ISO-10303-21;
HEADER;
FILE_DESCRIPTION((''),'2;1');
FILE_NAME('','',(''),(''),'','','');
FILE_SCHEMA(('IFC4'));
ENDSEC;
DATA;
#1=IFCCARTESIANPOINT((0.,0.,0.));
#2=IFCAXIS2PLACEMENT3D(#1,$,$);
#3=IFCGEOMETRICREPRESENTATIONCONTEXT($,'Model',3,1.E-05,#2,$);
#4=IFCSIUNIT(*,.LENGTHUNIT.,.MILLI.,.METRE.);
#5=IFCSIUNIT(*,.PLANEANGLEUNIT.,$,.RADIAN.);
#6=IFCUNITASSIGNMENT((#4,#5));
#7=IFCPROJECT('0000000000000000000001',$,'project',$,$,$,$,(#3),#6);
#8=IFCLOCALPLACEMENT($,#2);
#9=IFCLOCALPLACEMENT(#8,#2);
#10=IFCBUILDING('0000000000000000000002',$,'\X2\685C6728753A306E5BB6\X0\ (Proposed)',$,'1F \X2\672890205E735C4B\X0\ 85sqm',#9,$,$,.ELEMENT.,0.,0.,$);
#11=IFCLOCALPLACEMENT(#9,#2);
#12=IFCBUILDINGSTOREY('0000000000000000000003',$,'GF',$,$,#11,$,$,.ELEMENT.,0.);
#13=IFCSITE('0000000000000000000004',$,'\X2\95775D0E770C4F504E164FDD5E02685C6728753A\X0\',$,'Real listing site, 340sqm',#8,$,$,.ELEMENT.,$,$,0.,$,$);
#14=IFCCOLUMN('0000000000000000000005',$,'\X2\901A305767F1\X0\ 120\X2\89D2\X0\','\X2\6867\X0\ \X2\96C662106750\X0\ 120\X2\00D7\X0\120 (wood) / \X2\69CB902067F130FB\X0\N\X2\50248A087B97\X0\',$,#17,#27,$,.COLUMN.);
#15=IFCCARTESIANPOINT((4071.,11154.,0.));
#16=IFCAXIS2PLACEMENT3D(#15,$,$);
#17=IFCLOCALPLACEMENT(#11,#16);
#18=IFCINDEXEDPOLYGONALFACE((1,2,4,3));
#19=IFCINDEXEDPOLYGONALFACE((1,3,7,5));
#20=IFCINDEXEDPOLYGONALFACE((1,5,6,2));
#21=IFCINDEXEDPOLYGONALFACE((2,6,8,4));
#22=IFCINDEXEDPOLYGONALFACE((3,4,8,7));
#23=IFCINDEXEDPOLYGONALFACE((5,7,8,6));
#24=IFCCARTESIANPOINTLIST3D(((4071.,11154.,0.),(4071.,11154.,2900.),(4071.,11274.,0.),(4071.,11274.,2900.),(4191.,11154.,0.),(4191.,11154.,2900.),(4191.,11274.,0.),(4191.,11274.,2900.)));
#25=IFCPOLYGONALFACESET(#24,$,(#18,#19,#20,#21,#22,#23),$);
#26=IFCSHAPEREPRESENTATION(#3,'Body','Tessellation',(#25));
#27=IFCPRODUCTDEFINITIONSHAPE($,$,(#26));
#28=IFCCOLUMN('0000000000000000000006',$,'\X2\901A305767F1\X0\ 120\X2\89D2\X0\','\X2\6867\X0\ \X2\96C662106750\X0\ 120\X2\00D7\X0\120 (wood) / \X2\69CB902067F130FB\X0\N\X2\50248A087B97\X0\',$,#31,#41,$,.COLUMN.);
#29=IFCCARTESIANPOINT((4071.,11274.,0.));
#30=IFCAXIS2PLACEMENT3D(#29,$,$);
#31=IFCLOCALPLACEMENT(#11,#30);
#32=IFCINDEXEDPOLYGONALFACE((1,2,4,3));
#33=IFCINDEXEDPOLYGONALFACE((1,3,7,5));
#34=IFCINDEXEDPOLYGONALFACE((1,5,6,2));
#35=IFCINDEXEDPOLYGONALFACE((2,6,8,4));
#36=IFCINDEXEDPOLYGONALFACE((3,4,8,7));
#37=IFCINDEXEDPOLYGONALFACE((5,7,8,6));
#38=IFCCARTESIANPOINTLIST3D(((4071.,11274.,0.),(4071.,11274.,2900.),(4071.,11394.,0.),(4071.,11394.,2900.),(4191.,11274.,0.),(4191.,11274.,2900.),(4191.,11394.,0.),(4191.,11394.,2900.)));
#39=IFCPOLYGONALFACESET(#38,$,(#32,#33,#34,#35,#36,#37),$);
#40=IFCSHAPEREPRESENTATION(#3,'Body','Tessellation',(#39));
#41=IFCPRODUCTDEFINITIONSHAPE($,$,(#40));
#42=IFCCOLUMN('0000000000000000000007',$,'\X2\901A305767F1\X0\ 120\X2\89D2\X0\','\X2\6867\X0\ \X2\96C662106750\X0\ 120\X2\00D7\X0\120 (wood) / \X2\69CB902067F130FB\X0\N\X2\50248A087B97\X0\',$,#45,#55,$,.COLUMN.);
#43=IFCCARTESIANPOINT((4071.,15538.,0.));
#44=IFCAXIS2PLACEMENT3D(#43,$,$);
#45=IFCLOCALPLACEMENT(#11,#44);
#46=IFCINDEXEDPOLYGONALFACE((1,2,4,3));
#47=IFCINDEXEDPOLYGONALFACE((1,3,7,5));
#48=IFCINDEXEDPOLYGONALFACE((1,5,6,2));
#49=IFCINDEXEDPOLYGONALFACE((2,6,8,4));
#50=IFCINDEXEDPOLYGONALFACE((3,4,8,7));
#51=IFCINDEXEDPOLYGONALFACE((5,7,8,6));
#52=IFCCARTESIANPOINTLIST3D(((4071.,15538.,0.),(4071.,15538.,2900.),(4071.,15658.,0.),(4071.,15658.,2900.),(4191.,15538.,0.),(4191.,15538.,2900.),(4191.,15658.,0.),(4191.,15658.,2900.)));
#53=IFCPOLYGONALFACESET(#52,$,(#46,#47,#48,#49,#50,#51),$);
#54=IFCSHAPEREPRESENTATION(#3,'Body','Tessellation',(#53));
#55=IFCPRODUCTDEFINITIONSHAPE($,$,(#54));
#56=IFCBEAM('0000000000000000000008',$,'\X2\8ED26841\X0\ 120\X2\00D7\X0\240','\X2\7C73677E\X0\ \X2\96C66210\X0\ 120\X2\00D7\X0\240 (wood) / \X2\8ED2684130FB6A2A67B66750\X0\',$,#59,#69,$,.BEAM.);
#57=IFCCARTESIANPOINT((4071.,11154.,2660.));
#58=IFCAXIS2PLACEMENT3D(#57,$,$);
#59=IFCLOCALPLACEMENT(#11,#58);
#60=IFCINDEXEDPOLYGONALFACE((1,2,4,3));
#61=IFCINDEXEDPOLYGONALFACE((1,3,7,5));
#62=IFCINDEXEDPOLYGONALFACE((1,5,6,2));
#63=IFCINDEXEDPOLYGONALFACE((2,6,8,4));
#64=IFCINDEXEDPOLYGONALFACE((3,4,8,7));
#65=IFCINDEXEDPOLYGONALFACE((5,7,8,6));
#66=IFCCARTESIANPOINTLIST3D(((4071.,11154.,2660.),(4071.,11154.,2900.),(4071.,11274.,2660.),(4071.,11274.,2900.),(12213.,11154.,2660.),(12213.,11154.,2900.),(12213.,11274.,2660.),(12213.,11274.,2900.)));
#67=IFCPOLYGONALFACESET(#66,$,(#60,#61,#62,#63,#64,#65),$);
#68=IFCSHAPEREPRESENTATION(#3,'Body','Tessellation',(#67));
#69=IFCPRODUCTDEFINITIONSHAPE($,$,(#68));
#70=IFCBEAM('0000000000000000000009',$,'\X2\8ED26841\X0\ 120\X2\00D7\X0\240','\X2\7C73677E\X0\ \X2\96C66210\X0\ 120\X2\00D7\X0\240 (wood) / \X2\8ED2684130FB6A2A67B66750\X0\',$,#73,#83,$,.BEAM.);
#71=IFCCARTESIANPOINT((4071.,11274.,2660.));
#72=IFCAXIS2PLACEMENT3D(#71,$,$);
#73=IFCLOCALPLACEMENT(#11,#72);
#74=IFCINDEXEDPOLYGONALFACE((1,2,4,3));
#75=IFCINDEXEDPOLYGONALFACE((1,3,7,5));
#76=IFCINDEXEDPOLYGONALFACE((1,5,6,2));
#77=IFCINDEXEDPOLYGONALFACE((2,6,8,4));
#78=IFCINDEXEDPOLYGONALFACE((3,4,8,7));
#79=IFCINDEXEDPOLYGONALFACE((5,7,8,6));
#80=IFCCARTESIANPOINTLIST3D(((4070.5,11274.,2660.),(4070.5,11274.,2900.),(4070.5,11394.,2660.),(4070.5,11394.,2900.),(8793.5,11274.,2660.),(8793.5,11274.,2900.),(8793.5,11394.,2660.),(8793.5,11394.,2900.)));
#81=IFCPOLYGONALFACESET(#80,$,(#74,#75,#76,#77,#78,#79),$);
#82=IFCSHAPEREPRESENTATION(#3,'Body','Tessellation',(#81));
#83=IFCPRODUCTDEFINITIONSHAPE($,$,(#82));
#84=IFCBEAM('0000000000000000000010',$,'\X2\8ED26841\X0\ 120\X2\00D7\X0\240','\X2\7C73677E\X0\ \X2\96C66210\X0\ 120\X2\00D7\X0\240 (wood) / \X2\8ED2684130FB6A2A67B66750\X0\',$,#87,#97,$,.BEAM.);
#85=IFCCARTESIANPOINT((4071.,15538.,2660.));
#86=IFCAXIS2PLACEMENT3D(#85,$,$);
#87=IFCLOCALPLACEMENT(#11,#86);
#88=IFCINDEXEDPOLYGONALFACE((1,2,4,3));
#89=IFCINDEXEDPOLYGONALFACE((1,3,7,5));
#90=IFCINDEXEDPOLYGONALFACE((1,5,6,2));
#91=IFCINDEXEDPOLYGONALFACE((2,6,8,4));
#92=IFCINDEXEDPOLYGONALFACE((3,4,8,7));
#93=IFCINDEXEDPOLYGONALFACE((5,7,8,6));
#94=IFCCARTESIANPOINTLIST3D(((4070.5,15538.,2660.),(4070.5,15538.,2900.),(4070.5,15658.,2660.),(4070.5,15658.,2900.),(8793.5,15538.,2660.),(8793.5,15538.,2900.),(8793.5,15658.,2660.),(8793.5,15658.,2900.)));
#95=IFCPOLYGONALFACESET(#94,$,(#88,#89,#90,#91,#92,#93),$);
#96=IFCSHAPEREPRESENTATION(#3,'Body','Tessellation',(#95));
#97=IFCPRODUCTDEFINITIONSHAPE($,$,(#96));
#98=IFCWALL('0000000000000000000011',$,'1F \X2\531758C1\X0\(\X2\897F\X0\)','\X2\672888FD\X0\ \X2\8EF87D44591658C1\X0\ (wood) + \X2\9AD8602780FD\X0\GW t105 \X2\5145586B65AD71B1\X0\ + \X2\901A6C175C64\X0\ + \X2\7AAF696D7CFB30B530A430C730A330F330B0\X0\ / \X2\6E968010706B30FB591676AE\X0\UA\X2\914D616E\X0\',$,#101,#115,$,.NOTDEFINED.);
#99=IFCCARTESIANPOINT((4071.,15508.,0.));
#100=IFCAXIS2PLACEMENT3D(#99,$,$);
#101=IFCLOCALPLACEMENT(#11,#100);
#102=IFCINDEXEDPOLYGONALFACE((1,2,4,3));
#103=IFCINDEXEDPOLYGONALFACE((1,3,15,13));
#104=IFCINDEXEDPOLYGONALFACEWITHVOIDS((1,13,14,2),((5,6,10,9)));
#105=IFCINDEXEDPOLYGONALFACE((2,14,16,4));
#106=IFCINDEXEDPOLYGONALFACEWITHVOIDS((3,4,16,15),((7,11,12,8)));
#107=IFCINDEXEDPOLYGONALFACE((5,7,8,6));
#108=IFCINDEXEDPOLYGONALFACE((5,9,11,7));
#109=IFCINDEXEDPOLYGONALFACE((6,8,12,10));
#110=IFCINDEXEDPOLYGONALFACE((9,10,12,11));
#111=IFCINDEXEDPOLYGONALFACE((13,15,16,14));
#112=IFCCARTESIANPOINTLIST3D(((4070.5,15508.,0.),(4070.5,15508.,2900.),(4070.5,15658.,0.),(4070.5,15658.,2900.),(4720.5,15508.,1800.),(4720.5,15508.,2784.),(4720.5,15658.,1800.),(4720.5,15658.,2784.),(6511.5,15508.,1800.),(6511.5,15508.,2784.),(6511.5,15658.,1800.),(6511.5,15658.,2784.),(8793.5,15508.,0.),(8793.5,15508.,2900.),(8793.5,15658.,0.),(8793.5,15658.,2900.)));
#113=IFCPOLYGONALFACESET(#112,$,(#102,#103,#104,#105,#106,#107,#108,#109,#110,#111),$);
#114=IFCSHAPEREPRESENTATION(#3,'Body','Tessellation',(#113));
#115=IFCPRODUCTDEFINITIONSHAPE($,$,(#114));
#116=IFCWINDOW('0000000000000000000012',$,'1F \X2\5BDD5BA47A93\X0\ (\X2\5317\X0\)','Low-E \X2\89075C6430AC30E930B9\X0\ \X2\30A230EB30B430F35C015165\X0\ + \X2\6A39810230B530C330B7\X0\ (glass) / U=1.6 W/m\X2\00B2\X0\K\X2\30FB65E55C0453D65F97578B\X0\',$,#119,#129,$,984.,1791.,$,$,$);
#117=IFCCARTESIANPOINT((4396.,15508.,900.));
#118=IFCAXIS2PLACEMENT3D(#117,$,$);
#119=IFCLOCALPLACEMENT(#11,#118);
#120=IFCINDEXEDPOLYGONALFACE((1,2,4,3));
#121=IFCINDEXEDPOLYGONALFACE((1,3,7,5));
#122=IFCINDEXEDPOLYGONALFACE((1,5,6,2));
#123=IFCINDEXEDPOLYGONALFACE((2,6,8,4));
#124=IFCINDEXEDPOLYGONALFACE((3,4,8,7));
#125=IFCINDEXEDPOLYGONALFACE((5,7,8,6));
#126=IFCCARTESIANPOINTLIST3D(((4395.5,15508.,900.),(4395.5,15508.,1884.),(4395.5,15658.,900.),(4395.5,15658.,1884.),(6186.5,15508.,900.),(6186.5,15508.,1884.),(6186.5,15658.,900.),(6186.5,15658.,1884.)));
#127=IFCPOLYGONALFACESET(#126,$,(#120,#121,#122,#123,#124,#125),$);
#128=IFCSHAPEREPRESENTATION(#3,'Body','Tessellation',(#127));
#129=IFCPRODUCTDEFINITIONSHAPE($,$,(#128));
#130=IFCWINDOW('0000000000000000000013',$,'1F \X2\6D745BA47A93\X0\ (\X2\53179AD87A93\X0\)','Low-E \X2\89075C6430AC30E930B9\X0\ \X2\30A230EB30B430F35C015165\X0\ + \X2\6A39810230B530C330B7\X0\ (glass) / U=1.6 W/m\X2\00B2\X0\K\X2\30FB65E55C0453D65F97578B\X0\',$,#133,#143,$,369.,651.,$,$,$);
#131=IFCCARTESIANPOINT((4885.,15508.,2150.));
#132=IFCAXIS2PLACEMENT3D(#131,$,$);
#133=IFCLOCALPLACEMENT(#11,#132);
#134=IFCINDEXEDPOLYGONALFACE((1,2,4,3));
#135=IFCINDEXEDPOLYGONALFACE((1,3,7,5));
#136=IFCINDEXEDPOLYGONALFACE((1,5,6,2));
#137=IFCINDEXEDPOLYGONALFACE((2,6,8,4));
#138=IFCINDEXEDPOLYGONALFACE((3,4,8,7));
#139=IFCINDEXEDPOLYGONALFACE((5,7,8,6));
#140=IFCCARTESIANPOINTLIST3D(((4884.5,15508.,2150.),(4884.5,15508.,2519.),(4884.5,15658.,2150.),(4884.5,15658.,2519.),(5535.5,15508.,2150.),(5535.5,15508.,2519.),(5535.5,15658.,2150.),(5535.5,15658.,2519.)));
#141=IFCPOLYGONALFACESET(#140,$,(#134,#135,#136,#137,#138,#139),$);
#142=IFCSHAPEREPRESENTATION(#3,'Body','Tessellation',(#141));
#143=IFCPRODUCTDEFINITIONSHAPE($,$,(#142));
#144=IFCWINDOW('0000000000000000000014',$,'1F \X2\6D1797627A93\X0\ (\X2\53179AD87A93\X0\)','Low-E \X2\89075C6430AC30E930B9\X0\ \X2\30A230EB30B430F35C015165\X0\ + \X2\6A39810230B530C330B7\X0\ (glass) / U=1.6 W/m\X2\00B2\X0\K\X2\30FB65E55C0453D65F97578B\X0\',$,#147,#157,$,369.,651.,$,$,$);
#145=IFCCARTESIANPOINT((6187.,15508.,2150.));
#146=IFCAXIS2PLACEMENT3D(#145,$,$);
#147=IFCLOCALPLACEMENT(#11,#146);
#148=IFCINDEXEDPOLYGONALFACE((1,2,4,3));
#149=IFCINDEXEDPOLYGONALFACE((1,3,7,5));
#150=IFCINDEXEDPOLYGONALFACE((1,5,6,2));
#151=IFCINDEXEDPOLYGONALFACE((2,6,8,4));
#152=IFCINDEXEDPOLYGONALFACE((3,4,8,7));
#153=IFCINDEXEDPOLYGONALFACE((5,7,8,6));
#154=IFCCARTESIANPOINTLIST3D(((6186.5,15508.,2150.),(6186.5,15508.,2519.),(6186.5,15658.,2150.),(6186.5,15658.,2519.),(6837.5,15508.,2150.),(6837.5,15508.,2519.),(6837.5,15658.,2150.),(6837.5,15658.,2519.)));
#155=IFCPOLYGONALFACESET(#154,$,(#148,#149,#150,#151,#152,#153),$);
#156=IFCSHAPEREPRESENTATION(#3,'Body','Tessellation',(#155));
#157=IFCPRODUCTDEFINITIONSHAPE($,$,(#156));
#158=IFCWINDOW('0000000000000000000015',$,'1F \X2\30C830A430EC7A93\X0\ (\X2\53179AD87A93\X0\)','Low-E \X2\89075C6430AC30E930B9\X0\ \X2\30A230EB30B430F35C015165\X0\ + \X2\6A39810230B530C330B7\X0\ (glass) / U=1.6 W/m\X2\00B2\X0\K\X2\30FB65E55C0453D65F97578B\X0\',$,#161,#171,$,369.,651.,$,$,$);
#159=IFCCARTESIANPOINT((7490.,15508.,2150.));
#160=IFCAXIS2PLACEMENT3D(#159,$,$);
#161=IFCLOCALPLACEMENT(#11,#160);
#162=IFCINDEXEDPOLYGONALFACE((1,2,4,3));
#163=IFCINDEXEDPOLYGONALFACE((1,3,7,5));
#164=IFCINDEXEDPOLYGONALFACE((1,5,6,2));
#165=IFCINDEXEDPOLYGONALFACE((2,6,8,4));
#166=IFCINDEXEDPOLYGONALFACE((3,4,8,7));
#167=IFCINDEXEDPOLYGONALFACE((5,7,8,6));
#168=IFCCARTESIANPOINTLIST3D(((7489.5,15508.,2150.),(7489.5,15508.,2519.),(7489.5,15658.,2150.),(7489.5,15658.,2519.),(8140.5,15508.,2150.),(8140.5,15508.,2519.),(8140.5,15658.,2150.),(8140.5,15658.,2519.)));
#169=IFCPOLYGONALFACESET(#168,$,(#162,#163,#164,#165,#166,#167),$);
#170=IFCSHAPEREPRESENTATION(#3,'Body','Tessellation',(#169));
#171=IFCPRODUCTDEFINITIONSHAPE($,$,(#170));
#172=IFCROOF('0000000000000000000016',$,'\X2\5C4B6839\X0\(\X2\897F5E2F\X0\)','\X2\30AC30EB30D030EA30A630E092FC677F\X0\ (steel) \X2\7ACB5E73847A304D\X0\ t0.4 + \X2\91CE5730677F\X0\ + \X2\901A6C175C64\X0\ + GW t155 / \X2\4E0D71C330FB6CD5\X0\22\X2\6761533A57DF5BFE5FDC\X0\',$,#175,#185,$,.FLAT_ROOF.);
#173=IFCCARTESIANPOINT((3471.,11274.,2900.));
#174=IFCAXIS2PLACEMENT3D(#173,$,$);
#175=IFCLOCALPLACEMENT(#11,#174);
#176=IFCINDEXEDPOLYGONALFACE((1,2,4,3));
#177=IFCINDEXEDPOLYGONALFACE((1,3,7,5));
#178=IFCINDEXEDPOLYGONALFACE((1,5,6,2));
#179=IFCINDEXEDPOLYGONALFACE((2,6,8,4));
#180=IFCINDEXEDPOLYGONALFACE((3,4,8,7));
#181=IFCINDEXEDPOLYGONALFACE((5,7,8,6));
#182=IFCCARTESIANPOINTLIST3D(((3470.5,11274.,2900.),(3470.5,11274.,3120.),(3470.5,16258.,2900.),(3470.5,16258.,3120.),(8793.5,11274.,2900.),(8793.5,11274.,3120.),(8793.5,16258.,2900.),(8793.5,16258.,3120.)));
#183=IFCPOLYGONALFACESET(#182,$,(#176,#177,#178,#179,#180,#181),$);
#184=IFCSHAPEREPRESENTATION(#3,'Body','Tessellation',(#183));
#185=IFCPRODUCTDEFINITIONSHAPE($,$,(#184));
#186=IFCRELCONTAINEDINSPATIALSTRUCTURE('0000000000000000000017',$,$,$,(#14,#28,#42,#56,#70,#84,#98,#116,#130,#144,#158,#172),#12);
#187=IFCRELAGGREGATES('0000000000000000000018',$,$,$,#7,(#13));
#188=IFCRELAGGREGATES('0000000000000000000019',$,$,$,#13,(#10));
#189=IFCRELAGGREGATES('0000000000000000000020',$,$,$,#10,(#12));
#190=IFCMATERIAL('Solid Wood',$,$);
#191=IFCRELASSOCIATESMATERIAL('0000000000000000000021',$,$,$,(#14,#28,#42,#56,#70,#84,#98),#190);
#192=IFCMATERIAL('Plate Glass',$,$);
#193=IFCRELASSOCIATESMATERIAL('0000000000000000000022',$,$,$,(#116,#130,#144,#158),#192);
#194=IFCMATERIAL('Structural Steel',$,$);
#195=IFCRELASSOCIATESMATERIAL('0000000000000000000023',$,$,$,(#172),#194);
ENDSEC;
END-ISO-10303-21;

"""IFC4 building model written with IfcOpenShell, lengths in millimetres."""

from ifc_helpers import new_model, si_unit, frame, frame_2d, origin, place, context, project, spatial, rectangle, extrude, material, element, fill, save


model = new_model("IFC4")

# Units and contexts
model_context = context("Model", 3, precision=1e-05, world=origin())
ifc_project = project(units=[si_unit("LENGTHUNIT", "METRE", prefix="MILLI"), si_unit("PLANEANGLEUNIT", "RADIAN")], contexts=[model_context])

# Site, building, storey
site_placement = place(None, origin())
site = spatial("IfcSite", under=ifc_project, at=site_placement, Name="長崎県佐世保市桜木町", ObjectType="Real listing site, 340sqm", CompositionType="ELEMENT", RefElevation=0.0)
building_placement = place(site_placement, origin())
building = spatial("IfcBuilding", under=site, at=building_placement, Name="桜木町の家 (Proposed)", ObjectType="1F 木造平屋 85sqm", CompositionType="ELEMENT", ElevationOfRefHeight=0.0, ElevationOfTerrain=0.0)
storey_placement = place(building_placement, origin())
storey = spatial("IfcBuildingStorey", under=building, at=storey_placement, Name="GF", CompositionType="ELEMENT", Elevation=0.0)

# Columns
ifc_material_1 = material(Name="Solid Wood")
column_1_placement = place(storey_placement, frame((4071.0, 11154.0, 0.0)))
element("IfcColumn", 1, at=column_1_placement, inside=storey, material=ifc_material_1, Name="通し柱 120角", Description="桧 集成材 120×120 (wood) / 構造柱・N値計算", PredefinedType="COLUMN", context=model_context, shape_type="SweptSolid", body=[
    extrude(rectangle(XDim=120.0, YDim=120.0, at=frame_2d((60.0, 60.0))), frame((4071.0, 11154.0, 0.0)), (0.0, 0.0, 1.0), 2900.0),
])
column_2_placement = place(storey_placement, frame((4071.0, 11274.0, 0.0)))
element("IfcColumn", 2, at=column_2_placement, inside=storey, material=ifc_material_1, Name="通し柱 120角", Description="桧 集成材 120×120 (wood) / 構造柱・N値計算", PredefinedType="COLUMN", context=model_context, shape_type="SweptSolid", body=[
    extrude(rectangle(XDim=120.0, YDim=120.0, at=frame_2d((60.0, 60.0))), frame((4071.0, 11274.0, 0.0)), (0.0, 0.0, 1.0), 2900.0),
])
column_3_placement = place(storey_placement, frame((4071.0, 15538.0, 0.0)))
element("IfcColumn", 3, at=column_3_placement, inside=storey, material=ifc_material_1, Name="通し柱 120角", Description="桧 集成材 120×120 (wood) / 構造柱・N値計算", PredefinedType="COLUMN", context=model_context, shape_type="SweptSolid", body=[
    extrude(rectangle(XDim=120.0, YDim=120.0, at=frame_2d((60.0, 60.0))), frame((4071.0, 15538.0, 0.0)), (0.0, 0.0, 1.0), 2900.0),
])

# Beams
beam_1_placement = place(storey_placement, frame((4071.0, 11154.0, 2660.0)))
element("IfcBeam", 4, at=beam_1_placement, inside=storey, material=ifc_material_1, Name="軒桁 120×240", Description="米松 集成 120×240 (wood) / 軒桁・横架材", PredefinedType="BEAM", context=model_context, shape_type="SweptSolid", body=[
    extrude(rectangle(XDim=8142.0, YDim=120.0, at=frame_2d((4071.0, 60.0))), frame((4071.0, 11154.0, 2660.0)), (0.0, 0.0, 1.0), 240.0),
])
beam_2_placement = place(storey_placement, frame((4071.0, 11274.0, 2660.0)))
element("IfcBeam", 5, at=beam_2_placement, inside=storey, material=ifc_material_1, Name="軒桁 120×240", Description="米松 集成 120×240 (wood) / 軒桁・横架材", PredefinedType="BEAM", context=model_context, shape_type="SweptSolid", body=[
    extrude(rectangle(XDim=4723.0, YDim=120.0, at=frame_2d((2361.0, 60.0))), frame((4071.0, 11274.0, 2660.0)), (0.0, 0.0, 1.0), 240.0),
])
beam_3_placement = place(storey_placement, frame((4071.0, 15538.0, 2660.0)))
element("IfcBeam", 6, at=beam_3_placement, inside=storey, material=ifc_material_1, Name="軒桁 120×240", Description="米松 集成 120×240 (wood) / 軒桁・横架材", PredefinedType="BEAM", context=model_context, shape_type="SweptSolid", body=[
    extrude(rectangle(XDim=4723.0, YDim=120.0, at=frame_2d((2361.0, 60.0))), frame((4071.0, 15538.0, 2660.0)), (0.0, 0.0, 1.0), 240.0),
])

# Wall, openings, windows
wall_1_placement = place(storey_placement, frame((4071.0, 15508.0, 0.0)))
wall_1 = element("IfcWall", 7, at=wall_1_placement, inside=storey, material=ifc_material_1, Name="1F 北壁(西)", Description="木製 軸組外壁 (wood) + 高性能GW t105 充填断熱 + 通気層 + 窯業系サイディング / 準耐火・外皮UA配慮", PredefinedType="NOTDEFINED", context=model_context, shape_type="SweptSolid", body=[
    extrude(rectangle(XDim=4723.0, YDim=150.0, at=frame_2d((2361.0, 75.0))), frame((4071.0, 15508.0, 0.0)), (0.0, 0.0, 1.0), 2900.0),
])
opening_1_placement = place(storey_placement, frame((4396.0, 15508.0, 900.0)))
opening_1 = element("IfcOpeningElement", 8, at=opening_1_placement, cuts=wall_1, PredefinedType="NOTDEFINED", context=model_context, shape_type="SweptSolid", body=[
    extrude(rectangle(XDim=1791.0, YDim=150.0, at=frame_2d((895.0, 75.0))), frame((4396.0, 15508.0, 900.0)), (0.0, 0.0, 1.0), 984.0),
])
opening_2_placement = place(storey_placement, frame((4885.0, 15508.0, 2150.0)))
opening_2 = element("IfcOpeningElement", 9, at=opening_2_placement, cuts=wall_1, PredefinedType="NOTDEFINED", context=model_context, shape_type="SweptSolid", body=[
    extrude(rectangle(XDim=651.0, YDim=150.0, at=frame_2d((325.0, 75.0))), frame((4885.0, 15508.0, 2150.0)), (0.0, 0.0, 1.0), 369.0),
])
opening_3_placement = place(storey_placement, frame((6187.0, 15508.0, 2150.0)))
opening_3 = element("IfcOpeningElement", 10, at=opening_3_placement, cuts=wall_1, PredefinedType="NOTDEFINED", context=model_context, shape_type="SweptSolid", body=[
    extrude(rectangle(XDim=651.0, YDim=150.0, at=frame_2d((325.0, 75.0))), frame((6187.0, 15508.0, 2150.0)), (0.0, 0.0, 1.0), 369.0),
])
opening_4_placement = place(storey_placement, frame((7490.0, 15508.0, 2150.0)))
opening_4 = element("IfcOpeningElement", 11, at=opening_4_placement, cuts=wall_1, PredefinedType="NOTDEFINED", context=model_context, shape_type="SweptSolid", body=[
    extrude(rectangle(XDim=651.0, YDim=150.0, at=frame_2d((325.0, 75.0))), frame((7490.0, 15508.0, 2150.0)), (0.0, 0.0, 1.0), 369.0),
])
ifc_material_2 = material(Name="Plate Glass")
window_1_placement = place(storey_placement, frame((4396.0, 15508.0, 900.0)))
window_1 = element("IfcWindow", 12, at=window_1_placement, inside=storey, material=ifc_material_2, Name="1F 寝室窓 (北)", Description="Low-E 複層ガラス アルゴン封入 + 樹脂サッシ (glass) / U=1.6 W/m²K・日射取得型", OverallHeight=984.0, OverallWidth=1791.0, context=model_context, shape_type="SweptSolid", body=[
    extrude(rectangle(XDim=1791.0, YDim=150.0, at=frame_2d((895.0, 75.0))), frame((4396.0, 15508.0, 900.0)), (0.0, 0.0, 1.0), 984.0),
])
fill(opening_1, window_1)
window_2_placement = place(storey_placement, frame((4885.0, 15508.0, 2150.0)))
window_2 = element("IfcWindow", 13, at=window_2_placement, inside=storey, material=ifc_material_2, Name="1F 浴室窓 (北高窓)", Description="Low-E 複層ガラス アルゴン封入 + 樹脂サッシ (glass) / U=1.6 W/m²K・日射取得型", OverallHeight=369.0, OverallWidth=651.0, context=model_context, shape_type="SweptSolid", body=[
    extrude(rectangle(XDim=651.0, YDim=150.0, at=frame_2d((325.0, 75.0))), frame((4885.0, 15508.0, 2150.0)), (0.0, 0.0, 1.0), 369.0),
])
fill(opening_2, window_2)
window_3_placement = place(storey_placement, frame((6187.0, 15508.0, 2150.0)))
window_3 = element("IfcWindow", 14, at=window_3_placement, inside=storey, material=ifc_material_2, Name="1F 洗面窓 (北高窓)", Description="Low-E 複層ガラス アルゴン封入 + 樹脂サッシ (glass) / U=1.6 W/m²K・日射取得型", OverallHeight=369.0, OverallWidth=651.0, context=model_context, shape_type="SweptSolid", body=[
    extrude(rectangle(XDim=651.0, YDim=150.0, at=frame_2d((325.0, 75.0))), frame((6187.0, 15508.0, 2150.0)), (0.0, 0.0, 1.0), 369.0),
])
fill(opening_3, window_3)
window_4_placement = place(storey_placement, frame((7490.0, 15508.0, 2150.0)))
window_4 = element("IfcWindow", 15, at=window_4_placement, inside=storey, material=ifc_material_2, Name="1F トイレ窓 (北高窓)", Description="Low-E 複層ガラス アルゴン封入 + 樹脂サッシ (glass) / U=1.6 W/m²K・日射取得型", OverallHeight=369.0, OverallWidth=651.0, context=model_context, shape_type="SweptSolid", body=[
    extrude(rectangle(XDim=651.0, YDim=150.0, at=frame_2d((325.0, 75.0))), frame((7490.0, 15508.0, 2150.0)), (0.0, 0.0, 1.0), 369.0),
])
fill(opening_4, window_4)

# Roof
ifc_material_3 = material(Name="Structural Steel")
roof_placement = place(storey_placement, frame((3471.0, 11274.0, 2900.0)))
element("IfcRoof", 16, at=roof_placement, inside=storey, material=ifc_material_3, Name="屋根(西帯)", Description="ガルバリウム鋼板 (steel) 立平葺き t0.4 + 野地板 + 通気層 + GW t155 / 不燃・法22条区域対応", PredefinedType="FLAT_ROOF", context=model_context, shape_type="SweptSolid", body=[
    extrude(rectangle(XDim=5323.0, YDim=4984.0, at=frame_2d((2661.0, 2492.0))), frame((3471.0, 11274.0, 2900.0)), (0.0, 0.0, 1.0), 220.0),
])

save(model, "model.ifc")
